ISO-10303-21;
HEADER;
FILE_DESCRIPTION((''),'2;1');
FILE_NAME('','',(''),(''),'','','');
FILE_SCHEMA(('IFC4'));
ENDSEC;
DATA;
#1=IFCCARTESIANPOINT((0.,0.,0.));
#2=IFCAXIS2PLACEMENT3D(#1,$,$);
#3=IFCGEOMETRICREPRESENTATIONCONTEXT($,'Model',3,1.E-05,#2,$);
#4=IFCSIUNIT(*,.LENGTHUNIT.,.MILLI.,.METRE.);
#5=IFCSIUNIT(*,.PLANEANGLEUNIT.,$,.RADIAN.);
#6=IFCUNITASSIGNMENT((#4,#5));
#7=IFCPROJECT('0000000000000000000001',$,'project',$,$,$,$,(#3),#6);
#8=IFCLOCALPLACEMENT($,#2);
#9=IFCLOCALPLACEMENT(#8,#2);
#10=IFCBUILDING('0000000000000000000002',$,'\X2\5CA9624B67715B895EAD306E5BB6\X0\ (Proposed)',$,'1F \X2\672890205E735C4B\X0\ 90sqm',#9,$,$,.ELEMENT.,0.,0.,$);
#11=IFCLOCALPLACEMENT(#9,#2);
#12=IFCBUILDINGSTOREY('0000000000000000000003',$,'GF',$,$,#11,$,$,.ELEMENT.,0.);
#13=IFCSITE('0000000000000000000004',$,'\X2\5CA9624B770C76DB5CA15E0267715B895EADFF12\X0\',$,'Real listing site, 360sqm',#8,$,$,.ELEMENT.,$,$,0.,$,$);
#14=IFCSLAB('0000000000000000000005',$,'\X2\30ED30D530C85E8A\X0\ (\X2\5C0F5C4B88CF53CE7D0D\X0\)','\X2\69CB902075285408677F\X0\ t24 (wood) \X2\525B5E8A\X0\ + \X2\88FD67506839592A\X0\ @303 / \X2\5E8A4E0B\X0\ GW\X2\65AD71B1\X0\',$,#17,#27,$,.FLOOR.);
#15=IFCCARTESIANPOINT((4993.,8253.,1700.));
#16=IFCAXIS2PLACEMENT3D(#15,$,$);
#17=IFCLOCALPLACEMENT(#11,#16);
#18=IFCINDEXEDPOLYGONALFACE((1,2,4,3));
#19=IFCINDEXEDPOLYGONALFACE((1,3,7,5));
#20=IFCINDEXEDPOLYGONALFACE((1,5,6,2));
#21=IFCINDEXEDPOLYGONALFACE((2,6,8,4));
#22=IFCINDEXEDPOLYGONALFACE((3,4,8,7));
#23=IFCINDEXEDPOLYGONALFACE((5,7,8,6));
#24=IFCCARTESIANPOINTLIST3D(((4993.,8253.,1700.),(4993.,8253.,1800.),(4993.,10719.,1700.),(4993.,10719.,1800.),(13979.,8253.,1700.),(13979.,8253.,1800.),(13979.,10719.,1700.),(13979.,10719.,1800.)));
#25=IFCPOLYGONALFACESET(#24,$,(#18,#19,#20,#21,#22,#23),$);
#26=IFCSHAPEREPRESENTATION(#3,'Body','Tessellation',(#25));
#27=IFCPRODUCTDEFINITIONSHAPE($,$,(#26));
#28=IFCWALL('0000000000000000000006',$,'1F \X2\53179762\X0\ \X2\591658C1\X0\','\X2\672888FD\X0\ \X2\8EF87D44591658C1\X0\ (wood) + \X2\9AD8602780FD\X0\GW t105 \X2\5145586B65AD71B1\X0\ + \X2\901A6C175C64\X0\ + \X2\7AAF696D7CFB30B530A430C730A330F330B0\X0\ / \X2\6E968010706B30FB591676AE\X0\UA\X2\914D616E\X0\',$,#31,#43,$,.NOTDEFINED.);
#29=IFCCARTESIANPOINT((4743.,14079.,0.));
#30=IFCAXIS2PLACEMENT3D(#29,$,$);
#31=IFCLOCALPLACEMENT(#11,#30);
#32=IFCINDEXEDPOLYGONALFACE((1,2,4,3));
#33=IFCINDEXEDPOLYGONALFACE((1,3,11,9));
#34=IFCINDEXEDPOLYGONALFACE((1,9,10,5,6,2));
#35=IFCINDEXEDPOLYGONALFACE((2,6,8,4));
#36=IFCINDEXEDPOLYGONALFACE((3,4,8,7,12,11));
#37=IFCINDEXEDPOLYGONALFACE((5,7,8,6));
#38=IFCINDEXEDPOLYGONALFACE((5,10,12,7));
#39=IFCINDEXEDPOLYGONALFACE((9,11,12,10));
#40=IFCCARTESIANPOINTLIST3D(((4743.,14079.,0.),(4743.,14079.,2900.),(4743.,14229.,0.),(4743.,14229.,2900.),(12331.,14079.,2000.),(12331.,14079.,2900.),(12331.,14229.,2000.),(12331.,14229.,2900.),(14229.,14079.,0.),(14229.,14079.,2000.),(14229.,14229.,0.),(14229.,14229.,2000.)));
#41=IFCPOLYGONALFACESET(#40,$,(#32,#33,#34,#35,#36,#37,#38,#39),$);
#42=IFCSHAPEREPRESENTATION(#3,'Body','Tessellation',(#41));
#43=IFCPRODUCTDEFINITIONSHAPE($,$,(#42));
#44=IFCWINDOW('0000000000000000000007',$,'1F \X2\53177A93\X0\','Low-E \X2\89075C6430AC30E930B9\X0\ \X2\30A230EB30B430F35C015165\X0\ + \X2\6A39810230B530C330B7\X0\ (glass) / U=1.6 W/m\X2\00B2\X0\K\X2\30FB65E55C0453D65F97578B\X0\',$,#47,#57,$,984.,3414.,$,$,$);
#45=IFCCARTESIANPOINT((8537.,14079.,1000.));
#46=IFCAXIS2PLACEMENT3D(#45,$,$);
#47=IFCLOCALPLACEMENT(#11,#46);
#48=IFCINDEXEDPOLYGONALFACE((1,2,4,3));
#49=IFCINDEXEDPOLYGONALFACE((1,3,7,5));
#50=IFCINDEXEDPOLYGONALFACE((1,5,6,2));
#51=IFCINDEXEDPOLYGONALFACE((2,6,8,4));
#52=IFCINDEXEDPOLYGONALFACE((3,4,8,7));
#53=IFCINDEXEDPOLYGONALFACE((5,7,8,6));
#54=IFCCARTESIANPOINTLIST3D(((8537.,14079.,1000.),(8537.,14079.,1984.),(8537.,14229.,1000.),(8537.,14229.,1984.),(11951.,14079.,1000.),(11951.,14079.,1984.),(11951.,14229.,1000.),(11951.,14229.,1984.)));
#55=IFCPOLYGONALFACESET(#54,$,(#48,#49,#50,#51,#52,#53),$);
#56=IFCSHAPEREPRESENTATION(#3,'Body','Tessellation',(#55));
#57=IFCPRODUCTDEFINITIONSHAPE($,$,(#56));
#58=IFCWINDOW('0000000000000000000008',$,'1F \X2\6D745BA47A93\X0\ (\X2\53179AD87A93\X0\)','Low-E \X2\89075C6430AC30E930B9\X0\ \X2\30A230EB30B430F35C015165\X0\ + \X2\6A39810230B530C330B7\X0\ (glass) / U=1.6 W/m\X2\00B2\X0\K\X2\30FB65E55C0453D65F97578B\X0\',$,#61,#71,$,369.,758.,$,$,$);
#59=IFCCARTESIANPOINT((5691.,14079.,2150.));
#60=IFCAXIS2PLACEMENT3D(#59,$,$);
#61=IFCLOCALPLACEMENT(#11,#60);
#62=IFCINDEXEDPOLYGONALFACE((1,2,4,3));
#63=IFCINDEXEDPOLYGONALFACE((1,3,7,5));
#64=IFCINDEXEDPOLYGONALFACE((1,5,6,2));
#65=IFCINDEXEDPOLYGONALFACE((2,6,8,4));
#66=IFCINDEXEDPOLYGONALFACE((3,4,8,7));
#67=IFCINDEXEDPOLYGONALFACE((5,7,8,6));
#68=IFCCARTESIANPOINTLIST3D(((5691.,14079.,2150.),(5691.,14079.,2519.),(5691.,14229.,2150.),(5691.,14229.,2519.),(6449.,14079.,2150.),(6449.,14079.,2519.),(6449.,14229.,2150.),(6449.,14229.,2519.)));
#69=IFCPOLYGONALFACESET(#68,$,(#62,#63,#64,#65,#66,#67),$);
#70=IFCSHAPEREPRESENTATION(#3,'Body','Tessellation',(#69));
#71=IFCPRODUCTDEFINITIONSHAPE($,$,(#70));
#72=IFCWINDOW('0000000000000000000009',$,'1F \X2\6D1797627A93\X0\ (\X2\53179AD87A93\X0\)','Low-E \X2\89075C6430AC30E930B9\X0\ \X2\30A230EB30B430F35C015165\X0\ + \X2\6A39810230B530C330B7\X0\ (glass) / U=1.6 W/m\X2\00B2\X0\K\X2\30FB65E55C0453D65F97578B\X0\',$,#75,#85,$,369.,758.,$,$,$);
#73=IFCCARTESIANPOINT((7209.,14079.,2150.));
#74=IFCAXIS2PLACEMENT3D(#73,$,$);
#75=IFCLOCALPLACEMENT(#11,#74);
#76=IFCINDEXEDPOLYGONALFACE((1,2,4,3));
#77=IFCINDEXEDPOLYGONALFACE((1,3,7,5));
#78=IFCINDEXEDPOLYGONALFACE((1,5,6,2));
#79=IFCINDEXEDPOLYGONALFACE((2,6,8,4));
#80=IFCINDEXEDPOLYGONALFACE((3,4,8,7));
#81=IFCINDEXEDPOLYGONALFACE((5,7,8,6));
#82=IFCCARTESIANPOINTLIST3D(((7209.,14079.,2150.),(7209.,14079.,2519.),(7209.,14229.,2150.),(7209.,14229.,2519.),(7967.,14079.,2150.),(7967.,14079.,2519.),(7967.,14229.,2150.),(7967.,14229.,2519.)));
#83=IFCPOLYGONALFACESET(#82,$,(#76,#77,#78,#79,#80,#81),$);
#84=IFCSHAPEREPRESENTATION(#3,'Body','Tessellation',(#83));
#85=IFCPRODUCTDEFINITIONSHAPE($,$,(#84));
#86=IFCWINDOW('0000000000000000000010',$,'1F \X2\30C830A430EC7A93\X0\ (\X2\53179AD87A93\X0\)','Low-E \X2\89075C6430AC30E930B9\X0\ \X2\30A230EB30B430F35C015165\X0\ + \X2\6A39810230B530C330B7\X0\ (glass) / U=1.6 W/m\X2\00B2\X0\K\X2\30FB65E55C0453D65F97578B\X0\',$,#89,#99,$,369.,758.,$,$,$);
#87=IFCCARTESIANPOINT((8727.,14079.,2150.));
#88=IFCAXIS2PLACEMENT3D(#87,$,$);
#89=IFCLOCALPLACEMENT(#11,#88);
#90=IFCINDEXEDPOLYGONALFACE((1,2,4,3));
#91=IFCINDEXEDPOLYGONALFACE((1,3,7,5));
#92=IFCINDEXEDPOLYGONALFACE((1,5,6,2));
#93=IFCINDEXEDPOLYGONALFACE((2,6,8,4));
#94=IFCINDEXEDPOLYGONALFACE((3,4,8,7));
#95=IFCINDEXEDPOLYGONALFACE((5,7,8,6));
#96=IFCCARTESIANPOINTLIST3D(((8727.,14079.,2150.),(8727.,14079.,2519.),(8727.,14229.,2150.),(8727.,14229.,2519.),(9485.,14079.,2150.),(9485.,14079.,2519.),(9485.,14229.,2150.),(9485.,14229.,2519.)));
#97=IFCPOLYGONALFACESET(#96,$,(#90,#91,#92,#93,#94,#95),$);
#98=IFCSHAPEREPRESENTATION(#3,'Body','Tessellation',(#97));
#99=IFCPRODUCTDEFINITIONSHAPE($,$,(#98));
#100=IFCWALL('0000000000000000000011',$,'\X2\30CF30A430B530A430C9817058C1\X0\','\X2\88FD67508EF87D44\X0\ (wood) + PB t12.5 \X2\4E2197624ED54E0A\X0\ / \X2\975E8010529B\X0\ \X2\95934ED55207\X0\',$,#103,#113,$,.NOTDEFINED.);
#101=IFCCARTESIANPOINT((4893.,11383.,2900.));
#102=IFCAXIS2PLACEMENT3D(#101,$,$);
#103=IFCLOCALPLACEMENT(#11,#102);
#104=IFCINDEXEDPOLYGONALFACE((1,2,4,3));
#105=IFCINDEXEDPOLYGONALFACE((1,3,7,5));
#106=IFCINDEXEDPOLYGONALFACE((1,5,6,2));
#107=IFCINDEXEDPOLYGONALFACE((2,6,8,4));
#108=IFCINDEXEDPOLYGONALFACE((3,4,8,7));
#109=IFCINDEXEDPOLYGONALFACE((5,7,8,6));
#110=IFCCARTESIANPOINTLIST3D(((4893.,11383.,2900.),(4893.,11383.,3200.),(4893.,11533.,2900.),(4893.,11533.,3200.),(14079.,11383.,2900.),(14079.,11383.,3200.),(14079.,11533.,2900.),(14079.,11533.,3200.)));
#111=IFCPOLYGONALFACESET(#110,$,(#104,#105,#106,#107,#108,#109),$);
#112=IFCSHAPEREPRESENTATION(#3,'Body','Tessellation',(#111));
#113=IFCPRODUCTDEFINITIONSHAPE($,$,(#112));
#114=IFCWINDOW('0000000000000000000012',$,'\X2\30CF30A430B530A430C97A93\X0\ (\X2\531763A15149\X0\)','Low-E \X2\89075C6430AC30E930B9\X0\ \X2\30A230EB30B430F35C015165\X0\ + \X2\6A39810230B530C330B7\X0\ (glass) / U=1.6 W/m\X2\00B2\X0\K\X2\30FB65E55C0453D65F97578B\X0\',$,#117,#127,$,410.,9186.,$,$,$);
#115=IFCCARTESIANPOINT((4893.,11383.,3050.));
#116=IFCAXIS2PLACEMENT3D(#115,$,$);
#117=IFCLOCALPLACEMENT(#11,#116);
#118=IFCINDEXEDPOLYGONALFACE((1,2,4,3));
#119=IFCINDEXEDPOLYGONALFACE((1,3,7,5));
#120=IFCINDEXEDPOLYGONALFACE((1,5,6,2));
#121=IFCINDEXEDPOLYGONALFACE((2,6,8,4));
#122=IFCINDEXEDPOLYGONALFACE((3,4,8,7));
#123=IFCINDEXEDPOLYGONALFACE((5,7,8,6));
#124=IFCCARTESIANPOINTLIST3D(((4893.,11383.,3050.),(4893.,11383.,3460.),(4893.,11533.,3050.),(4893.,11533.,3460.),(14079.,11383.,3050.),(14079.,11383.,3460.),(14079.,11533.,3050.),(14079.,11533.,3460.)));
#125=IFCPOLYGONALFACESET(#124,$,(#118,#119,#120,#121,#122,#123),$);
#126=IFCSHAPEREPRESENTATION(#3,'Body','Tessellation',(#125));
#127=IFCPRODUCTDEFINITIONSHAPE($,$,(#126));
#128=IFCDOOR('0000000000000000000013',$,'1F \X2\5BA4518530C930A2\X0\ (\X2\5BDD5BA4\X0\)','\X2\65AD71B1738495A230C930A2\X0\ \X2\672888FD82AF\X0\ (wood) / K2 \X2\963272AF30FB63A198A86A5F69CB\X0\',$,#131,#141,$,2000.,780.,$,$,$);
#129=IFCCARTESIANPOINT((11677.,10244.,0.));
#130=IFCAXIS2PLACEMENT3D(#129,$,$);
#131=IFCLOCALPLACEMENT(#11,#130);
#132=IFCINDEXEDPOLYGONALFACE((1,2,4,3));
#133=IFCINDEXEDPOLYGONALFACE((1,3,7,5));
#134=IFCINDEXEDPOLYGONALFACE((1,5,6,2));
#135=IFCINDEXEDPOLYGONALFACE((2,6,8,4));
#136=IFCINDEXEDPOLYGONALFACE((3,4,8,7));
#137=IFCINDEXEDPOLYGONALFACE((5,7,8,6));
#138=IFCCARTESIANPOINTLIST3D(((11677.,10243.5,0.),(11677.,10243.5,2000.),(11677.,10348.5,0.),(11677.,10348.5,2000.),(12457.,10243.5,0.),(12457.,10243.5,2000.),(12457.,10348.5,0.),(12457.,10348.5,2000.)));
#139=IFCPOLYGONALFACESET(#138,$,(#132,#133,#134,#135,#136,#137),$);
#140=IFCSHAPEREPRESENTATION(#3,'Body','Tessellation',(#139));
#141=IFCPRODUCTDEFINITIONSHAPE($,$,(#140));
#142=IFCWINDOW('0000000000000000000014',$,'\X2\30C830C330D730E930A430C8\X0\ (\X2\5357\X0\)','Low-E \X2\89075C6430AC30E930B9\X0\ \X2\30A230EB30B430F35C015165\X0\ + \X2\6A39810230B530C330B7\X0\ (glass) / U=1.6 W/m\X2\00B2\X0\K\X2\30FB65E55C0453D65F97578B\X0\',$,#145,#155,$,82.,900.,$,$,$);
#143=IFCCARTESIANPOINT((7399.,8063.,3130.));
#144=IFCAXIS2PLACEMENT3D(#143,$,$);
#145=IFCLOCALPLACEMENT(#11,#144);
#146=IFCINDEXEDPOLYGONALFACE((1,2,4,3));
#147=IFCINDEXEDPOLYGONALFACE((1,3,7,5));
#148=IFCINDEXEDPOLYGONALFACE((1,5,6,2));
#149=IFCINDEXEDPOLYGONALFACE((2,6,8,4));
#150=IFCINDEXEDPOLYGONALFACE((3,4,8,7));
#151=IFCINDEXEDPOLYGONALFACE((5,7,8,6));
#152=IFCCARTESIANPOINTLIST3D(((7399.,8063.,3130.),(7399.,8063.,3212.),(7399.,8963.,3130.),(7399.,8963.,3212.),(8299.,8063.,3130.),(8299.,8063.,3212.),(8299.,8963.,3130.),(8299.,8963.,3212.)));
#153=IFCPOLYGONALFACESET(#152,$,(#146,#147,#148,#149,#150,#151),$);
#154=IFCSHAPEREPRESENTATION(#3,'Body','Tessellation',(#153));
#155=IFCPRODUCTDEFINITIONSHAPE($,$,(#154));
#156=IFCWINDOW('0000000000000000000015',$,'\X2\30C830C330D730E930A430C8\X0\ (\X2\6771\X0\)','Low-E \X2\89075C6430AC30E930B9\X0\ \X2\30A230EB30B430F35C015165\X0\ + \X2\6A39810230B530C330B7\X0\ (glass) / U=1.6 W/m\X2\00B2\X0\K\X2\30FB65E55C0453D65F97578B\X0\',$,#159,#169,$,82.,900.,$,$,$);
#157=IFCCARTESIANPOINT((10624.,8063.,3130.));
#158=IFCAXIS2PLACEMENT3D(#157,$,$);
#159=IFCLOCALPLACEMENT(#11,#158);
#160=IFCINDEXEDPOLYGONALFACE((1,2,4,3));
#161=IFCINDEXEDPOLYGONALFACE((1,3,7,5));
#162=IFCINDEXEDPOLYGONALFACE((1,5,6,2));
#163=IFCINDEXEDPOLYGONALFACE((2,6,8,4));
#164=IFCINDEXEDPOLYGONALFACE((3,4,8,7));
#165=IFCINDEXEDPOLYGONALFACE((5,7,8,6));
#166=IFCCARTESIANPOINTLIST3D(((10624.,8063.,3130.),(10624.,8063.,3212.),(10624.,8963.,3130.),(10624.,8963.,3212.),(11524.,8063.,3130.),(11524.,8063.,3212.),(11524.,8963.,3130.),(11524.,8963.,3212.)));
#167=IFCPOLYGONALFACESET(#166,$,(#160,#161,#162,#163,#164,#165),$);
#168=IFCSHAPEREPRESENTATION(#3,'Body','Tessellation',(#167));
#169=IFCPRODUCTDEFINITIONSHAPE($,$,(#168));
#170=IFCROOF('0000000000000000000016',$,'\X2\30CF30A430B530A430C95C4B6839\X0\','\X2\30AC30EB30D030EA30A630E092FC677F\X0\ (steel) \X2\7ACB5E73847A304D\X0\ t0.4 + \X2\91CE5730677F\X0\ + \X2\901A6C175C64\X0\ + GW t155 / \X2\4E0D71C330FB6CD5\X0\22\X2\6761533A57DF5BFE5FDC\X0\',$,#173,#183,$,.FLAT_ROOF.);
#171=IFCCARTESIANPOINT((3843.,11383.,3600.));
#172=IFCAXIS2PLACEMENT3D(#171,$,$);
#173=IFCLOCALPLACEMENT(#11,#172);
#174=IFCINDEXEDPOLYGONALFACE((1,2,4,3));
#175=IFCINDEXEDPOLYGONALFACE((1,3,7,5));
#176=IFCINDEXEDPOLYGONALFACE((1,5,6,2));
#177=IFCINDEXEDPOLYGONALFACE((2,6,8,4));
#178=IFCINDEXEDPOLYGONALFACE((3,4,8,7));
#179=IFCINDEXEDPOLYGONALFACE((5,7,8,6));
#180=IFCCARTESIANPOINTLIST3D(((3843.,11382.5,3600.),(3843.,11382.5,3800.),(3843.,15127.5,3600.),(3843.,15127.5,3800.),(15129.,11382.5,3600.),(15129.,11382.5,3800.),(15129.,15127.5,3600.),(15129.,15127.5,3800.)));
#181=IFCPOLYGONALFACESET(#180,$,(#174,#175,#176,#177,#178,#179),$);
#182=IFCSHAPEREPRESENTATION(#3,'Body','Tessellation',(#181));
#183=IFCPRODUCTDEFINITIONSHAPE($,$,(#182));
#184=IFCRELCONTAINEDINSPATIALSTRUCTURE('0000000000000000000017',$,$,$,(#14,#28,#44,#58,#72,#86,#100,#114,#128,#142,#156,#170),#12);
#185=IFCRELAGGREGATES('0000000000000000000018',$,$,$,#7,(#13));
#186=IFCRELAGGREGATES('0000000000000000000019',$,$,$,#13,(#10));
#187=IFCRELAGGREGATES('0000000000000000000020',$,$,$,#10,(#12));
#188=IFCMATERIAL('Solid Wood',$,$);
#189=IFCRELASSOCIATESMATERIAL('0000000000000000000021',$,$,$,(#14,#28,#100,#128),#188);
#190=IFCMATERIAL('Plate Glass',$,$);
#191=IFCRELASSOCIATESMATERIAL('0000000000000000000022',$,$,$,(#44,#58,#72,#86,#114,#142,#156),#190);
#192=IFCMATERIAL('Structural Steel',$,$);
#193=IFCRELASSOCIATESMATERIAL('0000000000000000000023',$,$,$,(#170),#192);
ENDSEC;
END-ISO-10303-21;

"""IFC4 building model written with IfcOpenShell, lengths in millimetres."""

from ifc_helpers import new_model, si_unit, frame, frame_2d, origin, place, context, project, spatial, rectangle, extrude, material, element, fill, save


model = new_model("IFC4")

# Units and contexts
model_context = context("Model", 3, precision=1e-05, world=origin())
ifc_project = project(units=[si_unit("LENGTHUNIT", "METRE", prefix="MILLI"), si_unit("PLANEANGLEUNIT", "RADIAN")], contexts=[model_context])

# Site, building, storey
site_placement = place(None, origin())
site = spatial("IfcSite", under=ifc_project, at=site_placement, Name="岩手県盛岡市東安庭２", ObjectType="Real listing site, 360sqm", CompositionType="ELEMENT", RefElevation=0.0)
building_placement = place(site_placement, origin())
building = spatial("IfcBuilding", under=site, at=building_placement, Name="岩手東安庭の家 (Proposed)", ObjectType="1F 木造平屋 90sqm", CompositionType="ELEMENT", ElevationOfRefHeight=0.0, ElevationOfTerrain=0.0)
storey_placement = place(building_placement, origin())
storey = spatial("IfcBuildingStorey", under=building, at=storey_placement, Name="GF", CompositionType="ELEMENT", Elevation=0.0)

# Slab
ifc_material_1 = material(Name="Solid Wood")
slab_placement = place(storey_placement, frame((4993.0, 8253.0, 1700.0)))
element("IfcSlab", 1, at=slab_placement, inside=storey, material=ifc_material_1, Name="ロフト床 (小屋裏収納)", Description="構造用合板 t24 (wood) 剛床 + 製材根太 @303 / 床下 GW断熱", PredefinedType="FLOOR", context=model_context, shape_type="SweptSolid", body=[
    extrude(rectangle(XDim=8986.0, YDim=2466.0, at=frame_2d((4493.0, 1233.0))), frame((4993.0, 8253.0, 1700.0)), (0.0, 0.0, 1.0), 100.0),
])

# Wall, openings, windows
wall_1_placement = place(storey_placement, frame((4743.0, 14079.0, 0.0)))
wall_1 = element("IfcWall", 2, at=wall_1_placement, inside=storey, material=ifc_material_1, Name="1F 北面 外壁", Description="木製 軸組外壁 (wood) + 高性能GW t105 充填断熱 + 通気層 + 窯業系サイディング / 準耐火・外皮UA配慮", PredefinedType="NOTDEFINED", context=model_context, shape_type="SweptSolid", body=[
    extrude(rectangle(XDim=9486.0, YDim=150.0, at=frame_2d((4743.0, 75.0))), frame((4743.0, 14079.0, 0.0)), (0.0, 0.0, 1.0), 2900.0),
])
opening_1_placement = place(storey_placement, frame((8537.0, 14079.0, 1000.0)))
opening_1 = element("IfcOpeningElement", 3, at=opening_1_placement, cuts=wall_1, PredefinedType="NOTDEFINED", context=model_context, shape_type="SweptSolid", body=[
    extrude(rectangle(XDim=3414.0, YDim=150.0, at=frame_2d((1707.0, 75.0))), frame((8537.0, 14079.0, 1000.0)), (0.0, 0.0, 1.0), 984.0),
])
opening_2_placement = place(storey_placement, frame((5691.0, 14079.0, 2150.0)))
opening_2 = element("IfcOpeningElement", 4, at=opening_2_placement, cuts=wall_1, PredefinedType="NOTDEFINED", context=model_context, shape_type="SweptSolid", body=[
    extrude(rectangle(XDim=758.0, YDim=150.0, at=frame_2d((379.0, 75.0))), frame((5691.0, 14079.0, 2150.0)), (0.0, 0.0, 1.0), 369.0),
])
opening_3_placement = place(storey_placement, frame((7209.0, 14079.0, 2150.0)))
opening_3 = element("IfcOpeningElement", 5, at=opening_3_placement, cuts=wall_1, PredefinedType="NOTDEFINED", context=model_context, shape_type="SweptSolid", body=[
    extrude(rectangle(XDim=758.0, YDim=150.0, at=frame_2d((379.0, 75.0))), frame((7209.0, 14079.0, 2150.0)), (0.0, 0.0, 1.0), 369.0),
])
opening_4_placement = place(storey_placement, frame((8727.0, 14079.0, 2150.0)))
opening_4 = element("IfcOpeningElement", 6, at=opening_4_placement, cuts=wall_1, PredefinedType="NOTDEFINED", context=model_context, shape_type="SweptSolid", body=[
    extrude(rectangle(XDim=758.0, YDim=150.0, at=frame_2d((379.0, 75.0))), frame((8727.0, 14079.0, 2150.0)), (0.0, 0.0, 1.0), 369.0),
])
ifc_material_2 = material(Name="Plate Glass")
window_1_placement = place(storey_placement, frame((8537.0, 14079.0, 1000.0)))
window_1 = element("IfcWindow", 7, at=window_1_placement, inside=storey, material=ifc_material_2, Name="1F 北窓", Description="Low-E 複層ガラス アルゴン封入 + 樹脂サッシ (glass) / U=1.6 W/m²K・日射取得型", OverallHeight=984.0, OverallWidth=3414.0, context=model_context, shape_type="SweptSolid", body=[
    extrude(rectangle(XDim=3414.0, YDim=150.0, at=frame_2d((1707.0, 75.0))), frame((8537.0, 14079.0, 1000.0)), (0.0, 0.0, 1.0), 984.0),
])
fill(opening_1, window_1)
window_2_placement = place(storey_placement, frame((5691.0, 14079.0, 2150.0)))
window_2 = element("IfcWindow", 8, at=window_2_placement, inside=storey, material=ifc_material_2, Name="1F 浴室窓 (北高窓)", Description="Low-E 複層ガラス アルゴン封入 + 樹脂サッシ (glass) / U=1.6 W/m²K・日射取得型", OverallHeight=369.0, OverallWidth=758.0, context=model_context, shape_type="SweptSolid", body=[
    extrude(rectangle(XDim=758.0, YDim=150.0, at=frame_2d((379.0, 75.0))), frame((5691.0, 14079.0, 2150.0)), (0.0, 0.0, 1.0), 369.0),
])
fill(opening_2, window_2)
window_3_placement = place(storey_placement, frame((7209.0, 14079.0, 2150.0)))
window_3 = element("IfcWindow", 9, at=window_3_placement, inside=storey, material=ifc_material_2, Name="1F 洗面窓 (北高窓)", Description="Low-E 複層ガラス アルゴン封入 + 樹脂サッシ (glass) / U=1.6 W/m²K・日射取得型", OverallHeight=369.0, OverallWidth=758.0, context=model_context, shape_type="SweptSolid", body=[
    extrude(rectangle(XDim=758.0, YDim=150.0, at=frame_2d((379.0, 75.0))), frame((7209.0, 14079.0, 2150.0)), (0.0, 0.0, 1.0), 369.0),
])
fill(opening_3, window_3)
window_4_placement = place(storey_placement, frame((8727.0, 14079.0, 2150.0)))
window_4 = element("IfcWindow", 10, at=window_4_placement, inside=storey, material=ifc_material_2, Name="1F トイレ窓 (北高窓)", Description="Low-E 複層ガラス アルゴン封入 + 樹脂サッシ (glass) / U=1.6 W/m²K・日射取得型", OverallHeight=369.0, OverallWidth=758.0, context=model_context, shape_type="SweptSolid", body=[
    extrude(rectangle(XDim=758.0, YDim=150.0, at=frame_2d((379.0, 75.0))), frame((8727.0, 14079.0, 2150.0)), (0.0, 0.0, 1.0), 369.0),
])
fill(opening_4, window_4)

# Wall, opening, window
wall_2_placement = place(storey_placement, frame((4893.0, 11383.0, 2900.0)))
wall_2 = element("IfcWall", 11, at=wall_2_placement, inside=storey, material=ifc_material_1, Name="ハイサイド腰壁", Description="製材軸組 (wood) + PB t12.5 両面仕上 / 非耐力 間仕切", PredefinedType="NOTDEFINED", context=model_context, shape_type="SweptSolid", body=[
    extrude(rectangle(XDim=9186.0, YDim=150.0, at=frame_2d((4593.0, 75.0))), frame((4893.0, 11383.0, 2900.0)), (0.0, 0.0, 1.0), 700.0),
])
opening_5_placement = place(storey_placement, frame((4893.0, 11383.0, 3050.0)))
opening_5 = element("IfcOpeningElement", 12, at=opening_5_placement, cuts=wall_2, PredefinedType="NOTDEFINED", context=model_context, shape_type="SweptSolid", body=[
    extrude(rectangle(XDim=9186.0, YDim=150.0, at=frame_2d((4593.0, 75.0))), frame((4893.0, 11383.0, 3050.0)), (0.0, 0.0, 1.0), 410.0),
])
window_5_placement = place(storey_placement, frame((4893.0, 11383.0, 3050.0)))
window_5 = element("IfcWindow", 13, at=window_5_placement, inside=storey, material=ifc_material_2, Name="ハイサイド窓 (北採光)", Description="Low-E 複層ガラス アルゴン封入 + 樹脂サッシ (glass) / U=1.6 W/m²K・日射取得型", OverallHeight=410.0, OverallWidth=9186.0, context=model_context, shape_type="SweptSolid", body=[
    extrude(rectangle(XDim=9186.0, YDim=150.0, at=frame_2d((4593.0, 75.0))), frame((4893.0, 11383.0, 3050.0)), (0.0, 0.0, 1.0), 410.0),
])
fill(opening_5, window_5)

# Door
door_1_placement = place(storey_placement, frame((11677.0, 10244.0, 0.0)))
element("IfcDoor", 14, at=door_1_placement, inside=storey, material=ifc_material_1, Name="1F 室内ドア (寝室)", Description="断熱玄関ドア 木製芯 (wood) / K2 防犯・採風機構", OverallHeight=2000.0, OverallWidth=780.0, context=model_context, shape_type="SweptSolid", body=[
    extrude(rectangle(XDim=780.0, YDim=105.0, at=frame_2d((390.0, 52.0))), frame((11677.0, 10244.0, 0.0)), (0.0, 0.0, 1.0), 2000.0),
])

# Windows
window_6_placement = place(storey_placement, frame((7399.0, 8063.0, 3130.0)))
element("IfcWindow", 15, at=window_6_placement, inside=storey, material=ifc_material_2, Name="トップライト (南)", Description="Low-E 複層ガラス アルゴン封入 + 樹脂サッシ (glass) / U=1.6 W/m²K・日射取得型", OverallHeight=82.0, OverallWidth=900.0, context=model_context, shape_type="SweptSolid", body=[
    extrude(rectangle(XDim=900.0, YDim=900.0, at=frame_2d((450.0, 450.0))), frame((7399.0, 8063.0, 3130.0)), (0.0, 0.0, 1.0), 82.0),
])
window_7_placement = place(storey_placement, frame((10624.0, 8063.0, 3130.0)))
element("IfcWindow", 16, at=window_7_placement, inside=storey, material=ifc_material_2, Name="トップライト (東)", Description="Low-E 複層ガラス アルゴン封入 + 樹脂サッシ (glass) / U=1.6 W/m²K・日射取得型", OverallHeight=82.0, OverallWidth=900.0, context=model_context, shape_type="SweptSolid", body=[
    extrude(rectangle(XDim=900.0, YDim=900.0, at=frame_2d((450.0, 450.0))), frame((10624.0, 8063.0, 3130.0)), (0.0, 0.0, 1.0), 82.0),
])

# Roof
ifc_material_3 = material(Name="Structural Steel")
roof_placement = place(storey_placement, frame((3843.0, 11383.0, 3600.0)))
element("IfcRoof", 17, at=roof_placement, inside=storey, material=ifc_material_3, Name="ハイサイド屋根", Description="ガルバリウム鋼板 (steel) 立平葺き t0.4 + 野地板 + 通気層 + GW t155 / 不燃・法22条区域対応", PredefinedType="FLAT_ROOF", context=model_context, shape_type="SweptSolid", body=[
    extrude(rectangle(XDim=11286.0, YDim=3745.0, at=frame_2d((5643.0, 1872.0))), frame((3843.0, 11383.0, 3600.0)), (0.0, 0.0, 1.0), 200.0),
])

save(model, "model.ifc")
